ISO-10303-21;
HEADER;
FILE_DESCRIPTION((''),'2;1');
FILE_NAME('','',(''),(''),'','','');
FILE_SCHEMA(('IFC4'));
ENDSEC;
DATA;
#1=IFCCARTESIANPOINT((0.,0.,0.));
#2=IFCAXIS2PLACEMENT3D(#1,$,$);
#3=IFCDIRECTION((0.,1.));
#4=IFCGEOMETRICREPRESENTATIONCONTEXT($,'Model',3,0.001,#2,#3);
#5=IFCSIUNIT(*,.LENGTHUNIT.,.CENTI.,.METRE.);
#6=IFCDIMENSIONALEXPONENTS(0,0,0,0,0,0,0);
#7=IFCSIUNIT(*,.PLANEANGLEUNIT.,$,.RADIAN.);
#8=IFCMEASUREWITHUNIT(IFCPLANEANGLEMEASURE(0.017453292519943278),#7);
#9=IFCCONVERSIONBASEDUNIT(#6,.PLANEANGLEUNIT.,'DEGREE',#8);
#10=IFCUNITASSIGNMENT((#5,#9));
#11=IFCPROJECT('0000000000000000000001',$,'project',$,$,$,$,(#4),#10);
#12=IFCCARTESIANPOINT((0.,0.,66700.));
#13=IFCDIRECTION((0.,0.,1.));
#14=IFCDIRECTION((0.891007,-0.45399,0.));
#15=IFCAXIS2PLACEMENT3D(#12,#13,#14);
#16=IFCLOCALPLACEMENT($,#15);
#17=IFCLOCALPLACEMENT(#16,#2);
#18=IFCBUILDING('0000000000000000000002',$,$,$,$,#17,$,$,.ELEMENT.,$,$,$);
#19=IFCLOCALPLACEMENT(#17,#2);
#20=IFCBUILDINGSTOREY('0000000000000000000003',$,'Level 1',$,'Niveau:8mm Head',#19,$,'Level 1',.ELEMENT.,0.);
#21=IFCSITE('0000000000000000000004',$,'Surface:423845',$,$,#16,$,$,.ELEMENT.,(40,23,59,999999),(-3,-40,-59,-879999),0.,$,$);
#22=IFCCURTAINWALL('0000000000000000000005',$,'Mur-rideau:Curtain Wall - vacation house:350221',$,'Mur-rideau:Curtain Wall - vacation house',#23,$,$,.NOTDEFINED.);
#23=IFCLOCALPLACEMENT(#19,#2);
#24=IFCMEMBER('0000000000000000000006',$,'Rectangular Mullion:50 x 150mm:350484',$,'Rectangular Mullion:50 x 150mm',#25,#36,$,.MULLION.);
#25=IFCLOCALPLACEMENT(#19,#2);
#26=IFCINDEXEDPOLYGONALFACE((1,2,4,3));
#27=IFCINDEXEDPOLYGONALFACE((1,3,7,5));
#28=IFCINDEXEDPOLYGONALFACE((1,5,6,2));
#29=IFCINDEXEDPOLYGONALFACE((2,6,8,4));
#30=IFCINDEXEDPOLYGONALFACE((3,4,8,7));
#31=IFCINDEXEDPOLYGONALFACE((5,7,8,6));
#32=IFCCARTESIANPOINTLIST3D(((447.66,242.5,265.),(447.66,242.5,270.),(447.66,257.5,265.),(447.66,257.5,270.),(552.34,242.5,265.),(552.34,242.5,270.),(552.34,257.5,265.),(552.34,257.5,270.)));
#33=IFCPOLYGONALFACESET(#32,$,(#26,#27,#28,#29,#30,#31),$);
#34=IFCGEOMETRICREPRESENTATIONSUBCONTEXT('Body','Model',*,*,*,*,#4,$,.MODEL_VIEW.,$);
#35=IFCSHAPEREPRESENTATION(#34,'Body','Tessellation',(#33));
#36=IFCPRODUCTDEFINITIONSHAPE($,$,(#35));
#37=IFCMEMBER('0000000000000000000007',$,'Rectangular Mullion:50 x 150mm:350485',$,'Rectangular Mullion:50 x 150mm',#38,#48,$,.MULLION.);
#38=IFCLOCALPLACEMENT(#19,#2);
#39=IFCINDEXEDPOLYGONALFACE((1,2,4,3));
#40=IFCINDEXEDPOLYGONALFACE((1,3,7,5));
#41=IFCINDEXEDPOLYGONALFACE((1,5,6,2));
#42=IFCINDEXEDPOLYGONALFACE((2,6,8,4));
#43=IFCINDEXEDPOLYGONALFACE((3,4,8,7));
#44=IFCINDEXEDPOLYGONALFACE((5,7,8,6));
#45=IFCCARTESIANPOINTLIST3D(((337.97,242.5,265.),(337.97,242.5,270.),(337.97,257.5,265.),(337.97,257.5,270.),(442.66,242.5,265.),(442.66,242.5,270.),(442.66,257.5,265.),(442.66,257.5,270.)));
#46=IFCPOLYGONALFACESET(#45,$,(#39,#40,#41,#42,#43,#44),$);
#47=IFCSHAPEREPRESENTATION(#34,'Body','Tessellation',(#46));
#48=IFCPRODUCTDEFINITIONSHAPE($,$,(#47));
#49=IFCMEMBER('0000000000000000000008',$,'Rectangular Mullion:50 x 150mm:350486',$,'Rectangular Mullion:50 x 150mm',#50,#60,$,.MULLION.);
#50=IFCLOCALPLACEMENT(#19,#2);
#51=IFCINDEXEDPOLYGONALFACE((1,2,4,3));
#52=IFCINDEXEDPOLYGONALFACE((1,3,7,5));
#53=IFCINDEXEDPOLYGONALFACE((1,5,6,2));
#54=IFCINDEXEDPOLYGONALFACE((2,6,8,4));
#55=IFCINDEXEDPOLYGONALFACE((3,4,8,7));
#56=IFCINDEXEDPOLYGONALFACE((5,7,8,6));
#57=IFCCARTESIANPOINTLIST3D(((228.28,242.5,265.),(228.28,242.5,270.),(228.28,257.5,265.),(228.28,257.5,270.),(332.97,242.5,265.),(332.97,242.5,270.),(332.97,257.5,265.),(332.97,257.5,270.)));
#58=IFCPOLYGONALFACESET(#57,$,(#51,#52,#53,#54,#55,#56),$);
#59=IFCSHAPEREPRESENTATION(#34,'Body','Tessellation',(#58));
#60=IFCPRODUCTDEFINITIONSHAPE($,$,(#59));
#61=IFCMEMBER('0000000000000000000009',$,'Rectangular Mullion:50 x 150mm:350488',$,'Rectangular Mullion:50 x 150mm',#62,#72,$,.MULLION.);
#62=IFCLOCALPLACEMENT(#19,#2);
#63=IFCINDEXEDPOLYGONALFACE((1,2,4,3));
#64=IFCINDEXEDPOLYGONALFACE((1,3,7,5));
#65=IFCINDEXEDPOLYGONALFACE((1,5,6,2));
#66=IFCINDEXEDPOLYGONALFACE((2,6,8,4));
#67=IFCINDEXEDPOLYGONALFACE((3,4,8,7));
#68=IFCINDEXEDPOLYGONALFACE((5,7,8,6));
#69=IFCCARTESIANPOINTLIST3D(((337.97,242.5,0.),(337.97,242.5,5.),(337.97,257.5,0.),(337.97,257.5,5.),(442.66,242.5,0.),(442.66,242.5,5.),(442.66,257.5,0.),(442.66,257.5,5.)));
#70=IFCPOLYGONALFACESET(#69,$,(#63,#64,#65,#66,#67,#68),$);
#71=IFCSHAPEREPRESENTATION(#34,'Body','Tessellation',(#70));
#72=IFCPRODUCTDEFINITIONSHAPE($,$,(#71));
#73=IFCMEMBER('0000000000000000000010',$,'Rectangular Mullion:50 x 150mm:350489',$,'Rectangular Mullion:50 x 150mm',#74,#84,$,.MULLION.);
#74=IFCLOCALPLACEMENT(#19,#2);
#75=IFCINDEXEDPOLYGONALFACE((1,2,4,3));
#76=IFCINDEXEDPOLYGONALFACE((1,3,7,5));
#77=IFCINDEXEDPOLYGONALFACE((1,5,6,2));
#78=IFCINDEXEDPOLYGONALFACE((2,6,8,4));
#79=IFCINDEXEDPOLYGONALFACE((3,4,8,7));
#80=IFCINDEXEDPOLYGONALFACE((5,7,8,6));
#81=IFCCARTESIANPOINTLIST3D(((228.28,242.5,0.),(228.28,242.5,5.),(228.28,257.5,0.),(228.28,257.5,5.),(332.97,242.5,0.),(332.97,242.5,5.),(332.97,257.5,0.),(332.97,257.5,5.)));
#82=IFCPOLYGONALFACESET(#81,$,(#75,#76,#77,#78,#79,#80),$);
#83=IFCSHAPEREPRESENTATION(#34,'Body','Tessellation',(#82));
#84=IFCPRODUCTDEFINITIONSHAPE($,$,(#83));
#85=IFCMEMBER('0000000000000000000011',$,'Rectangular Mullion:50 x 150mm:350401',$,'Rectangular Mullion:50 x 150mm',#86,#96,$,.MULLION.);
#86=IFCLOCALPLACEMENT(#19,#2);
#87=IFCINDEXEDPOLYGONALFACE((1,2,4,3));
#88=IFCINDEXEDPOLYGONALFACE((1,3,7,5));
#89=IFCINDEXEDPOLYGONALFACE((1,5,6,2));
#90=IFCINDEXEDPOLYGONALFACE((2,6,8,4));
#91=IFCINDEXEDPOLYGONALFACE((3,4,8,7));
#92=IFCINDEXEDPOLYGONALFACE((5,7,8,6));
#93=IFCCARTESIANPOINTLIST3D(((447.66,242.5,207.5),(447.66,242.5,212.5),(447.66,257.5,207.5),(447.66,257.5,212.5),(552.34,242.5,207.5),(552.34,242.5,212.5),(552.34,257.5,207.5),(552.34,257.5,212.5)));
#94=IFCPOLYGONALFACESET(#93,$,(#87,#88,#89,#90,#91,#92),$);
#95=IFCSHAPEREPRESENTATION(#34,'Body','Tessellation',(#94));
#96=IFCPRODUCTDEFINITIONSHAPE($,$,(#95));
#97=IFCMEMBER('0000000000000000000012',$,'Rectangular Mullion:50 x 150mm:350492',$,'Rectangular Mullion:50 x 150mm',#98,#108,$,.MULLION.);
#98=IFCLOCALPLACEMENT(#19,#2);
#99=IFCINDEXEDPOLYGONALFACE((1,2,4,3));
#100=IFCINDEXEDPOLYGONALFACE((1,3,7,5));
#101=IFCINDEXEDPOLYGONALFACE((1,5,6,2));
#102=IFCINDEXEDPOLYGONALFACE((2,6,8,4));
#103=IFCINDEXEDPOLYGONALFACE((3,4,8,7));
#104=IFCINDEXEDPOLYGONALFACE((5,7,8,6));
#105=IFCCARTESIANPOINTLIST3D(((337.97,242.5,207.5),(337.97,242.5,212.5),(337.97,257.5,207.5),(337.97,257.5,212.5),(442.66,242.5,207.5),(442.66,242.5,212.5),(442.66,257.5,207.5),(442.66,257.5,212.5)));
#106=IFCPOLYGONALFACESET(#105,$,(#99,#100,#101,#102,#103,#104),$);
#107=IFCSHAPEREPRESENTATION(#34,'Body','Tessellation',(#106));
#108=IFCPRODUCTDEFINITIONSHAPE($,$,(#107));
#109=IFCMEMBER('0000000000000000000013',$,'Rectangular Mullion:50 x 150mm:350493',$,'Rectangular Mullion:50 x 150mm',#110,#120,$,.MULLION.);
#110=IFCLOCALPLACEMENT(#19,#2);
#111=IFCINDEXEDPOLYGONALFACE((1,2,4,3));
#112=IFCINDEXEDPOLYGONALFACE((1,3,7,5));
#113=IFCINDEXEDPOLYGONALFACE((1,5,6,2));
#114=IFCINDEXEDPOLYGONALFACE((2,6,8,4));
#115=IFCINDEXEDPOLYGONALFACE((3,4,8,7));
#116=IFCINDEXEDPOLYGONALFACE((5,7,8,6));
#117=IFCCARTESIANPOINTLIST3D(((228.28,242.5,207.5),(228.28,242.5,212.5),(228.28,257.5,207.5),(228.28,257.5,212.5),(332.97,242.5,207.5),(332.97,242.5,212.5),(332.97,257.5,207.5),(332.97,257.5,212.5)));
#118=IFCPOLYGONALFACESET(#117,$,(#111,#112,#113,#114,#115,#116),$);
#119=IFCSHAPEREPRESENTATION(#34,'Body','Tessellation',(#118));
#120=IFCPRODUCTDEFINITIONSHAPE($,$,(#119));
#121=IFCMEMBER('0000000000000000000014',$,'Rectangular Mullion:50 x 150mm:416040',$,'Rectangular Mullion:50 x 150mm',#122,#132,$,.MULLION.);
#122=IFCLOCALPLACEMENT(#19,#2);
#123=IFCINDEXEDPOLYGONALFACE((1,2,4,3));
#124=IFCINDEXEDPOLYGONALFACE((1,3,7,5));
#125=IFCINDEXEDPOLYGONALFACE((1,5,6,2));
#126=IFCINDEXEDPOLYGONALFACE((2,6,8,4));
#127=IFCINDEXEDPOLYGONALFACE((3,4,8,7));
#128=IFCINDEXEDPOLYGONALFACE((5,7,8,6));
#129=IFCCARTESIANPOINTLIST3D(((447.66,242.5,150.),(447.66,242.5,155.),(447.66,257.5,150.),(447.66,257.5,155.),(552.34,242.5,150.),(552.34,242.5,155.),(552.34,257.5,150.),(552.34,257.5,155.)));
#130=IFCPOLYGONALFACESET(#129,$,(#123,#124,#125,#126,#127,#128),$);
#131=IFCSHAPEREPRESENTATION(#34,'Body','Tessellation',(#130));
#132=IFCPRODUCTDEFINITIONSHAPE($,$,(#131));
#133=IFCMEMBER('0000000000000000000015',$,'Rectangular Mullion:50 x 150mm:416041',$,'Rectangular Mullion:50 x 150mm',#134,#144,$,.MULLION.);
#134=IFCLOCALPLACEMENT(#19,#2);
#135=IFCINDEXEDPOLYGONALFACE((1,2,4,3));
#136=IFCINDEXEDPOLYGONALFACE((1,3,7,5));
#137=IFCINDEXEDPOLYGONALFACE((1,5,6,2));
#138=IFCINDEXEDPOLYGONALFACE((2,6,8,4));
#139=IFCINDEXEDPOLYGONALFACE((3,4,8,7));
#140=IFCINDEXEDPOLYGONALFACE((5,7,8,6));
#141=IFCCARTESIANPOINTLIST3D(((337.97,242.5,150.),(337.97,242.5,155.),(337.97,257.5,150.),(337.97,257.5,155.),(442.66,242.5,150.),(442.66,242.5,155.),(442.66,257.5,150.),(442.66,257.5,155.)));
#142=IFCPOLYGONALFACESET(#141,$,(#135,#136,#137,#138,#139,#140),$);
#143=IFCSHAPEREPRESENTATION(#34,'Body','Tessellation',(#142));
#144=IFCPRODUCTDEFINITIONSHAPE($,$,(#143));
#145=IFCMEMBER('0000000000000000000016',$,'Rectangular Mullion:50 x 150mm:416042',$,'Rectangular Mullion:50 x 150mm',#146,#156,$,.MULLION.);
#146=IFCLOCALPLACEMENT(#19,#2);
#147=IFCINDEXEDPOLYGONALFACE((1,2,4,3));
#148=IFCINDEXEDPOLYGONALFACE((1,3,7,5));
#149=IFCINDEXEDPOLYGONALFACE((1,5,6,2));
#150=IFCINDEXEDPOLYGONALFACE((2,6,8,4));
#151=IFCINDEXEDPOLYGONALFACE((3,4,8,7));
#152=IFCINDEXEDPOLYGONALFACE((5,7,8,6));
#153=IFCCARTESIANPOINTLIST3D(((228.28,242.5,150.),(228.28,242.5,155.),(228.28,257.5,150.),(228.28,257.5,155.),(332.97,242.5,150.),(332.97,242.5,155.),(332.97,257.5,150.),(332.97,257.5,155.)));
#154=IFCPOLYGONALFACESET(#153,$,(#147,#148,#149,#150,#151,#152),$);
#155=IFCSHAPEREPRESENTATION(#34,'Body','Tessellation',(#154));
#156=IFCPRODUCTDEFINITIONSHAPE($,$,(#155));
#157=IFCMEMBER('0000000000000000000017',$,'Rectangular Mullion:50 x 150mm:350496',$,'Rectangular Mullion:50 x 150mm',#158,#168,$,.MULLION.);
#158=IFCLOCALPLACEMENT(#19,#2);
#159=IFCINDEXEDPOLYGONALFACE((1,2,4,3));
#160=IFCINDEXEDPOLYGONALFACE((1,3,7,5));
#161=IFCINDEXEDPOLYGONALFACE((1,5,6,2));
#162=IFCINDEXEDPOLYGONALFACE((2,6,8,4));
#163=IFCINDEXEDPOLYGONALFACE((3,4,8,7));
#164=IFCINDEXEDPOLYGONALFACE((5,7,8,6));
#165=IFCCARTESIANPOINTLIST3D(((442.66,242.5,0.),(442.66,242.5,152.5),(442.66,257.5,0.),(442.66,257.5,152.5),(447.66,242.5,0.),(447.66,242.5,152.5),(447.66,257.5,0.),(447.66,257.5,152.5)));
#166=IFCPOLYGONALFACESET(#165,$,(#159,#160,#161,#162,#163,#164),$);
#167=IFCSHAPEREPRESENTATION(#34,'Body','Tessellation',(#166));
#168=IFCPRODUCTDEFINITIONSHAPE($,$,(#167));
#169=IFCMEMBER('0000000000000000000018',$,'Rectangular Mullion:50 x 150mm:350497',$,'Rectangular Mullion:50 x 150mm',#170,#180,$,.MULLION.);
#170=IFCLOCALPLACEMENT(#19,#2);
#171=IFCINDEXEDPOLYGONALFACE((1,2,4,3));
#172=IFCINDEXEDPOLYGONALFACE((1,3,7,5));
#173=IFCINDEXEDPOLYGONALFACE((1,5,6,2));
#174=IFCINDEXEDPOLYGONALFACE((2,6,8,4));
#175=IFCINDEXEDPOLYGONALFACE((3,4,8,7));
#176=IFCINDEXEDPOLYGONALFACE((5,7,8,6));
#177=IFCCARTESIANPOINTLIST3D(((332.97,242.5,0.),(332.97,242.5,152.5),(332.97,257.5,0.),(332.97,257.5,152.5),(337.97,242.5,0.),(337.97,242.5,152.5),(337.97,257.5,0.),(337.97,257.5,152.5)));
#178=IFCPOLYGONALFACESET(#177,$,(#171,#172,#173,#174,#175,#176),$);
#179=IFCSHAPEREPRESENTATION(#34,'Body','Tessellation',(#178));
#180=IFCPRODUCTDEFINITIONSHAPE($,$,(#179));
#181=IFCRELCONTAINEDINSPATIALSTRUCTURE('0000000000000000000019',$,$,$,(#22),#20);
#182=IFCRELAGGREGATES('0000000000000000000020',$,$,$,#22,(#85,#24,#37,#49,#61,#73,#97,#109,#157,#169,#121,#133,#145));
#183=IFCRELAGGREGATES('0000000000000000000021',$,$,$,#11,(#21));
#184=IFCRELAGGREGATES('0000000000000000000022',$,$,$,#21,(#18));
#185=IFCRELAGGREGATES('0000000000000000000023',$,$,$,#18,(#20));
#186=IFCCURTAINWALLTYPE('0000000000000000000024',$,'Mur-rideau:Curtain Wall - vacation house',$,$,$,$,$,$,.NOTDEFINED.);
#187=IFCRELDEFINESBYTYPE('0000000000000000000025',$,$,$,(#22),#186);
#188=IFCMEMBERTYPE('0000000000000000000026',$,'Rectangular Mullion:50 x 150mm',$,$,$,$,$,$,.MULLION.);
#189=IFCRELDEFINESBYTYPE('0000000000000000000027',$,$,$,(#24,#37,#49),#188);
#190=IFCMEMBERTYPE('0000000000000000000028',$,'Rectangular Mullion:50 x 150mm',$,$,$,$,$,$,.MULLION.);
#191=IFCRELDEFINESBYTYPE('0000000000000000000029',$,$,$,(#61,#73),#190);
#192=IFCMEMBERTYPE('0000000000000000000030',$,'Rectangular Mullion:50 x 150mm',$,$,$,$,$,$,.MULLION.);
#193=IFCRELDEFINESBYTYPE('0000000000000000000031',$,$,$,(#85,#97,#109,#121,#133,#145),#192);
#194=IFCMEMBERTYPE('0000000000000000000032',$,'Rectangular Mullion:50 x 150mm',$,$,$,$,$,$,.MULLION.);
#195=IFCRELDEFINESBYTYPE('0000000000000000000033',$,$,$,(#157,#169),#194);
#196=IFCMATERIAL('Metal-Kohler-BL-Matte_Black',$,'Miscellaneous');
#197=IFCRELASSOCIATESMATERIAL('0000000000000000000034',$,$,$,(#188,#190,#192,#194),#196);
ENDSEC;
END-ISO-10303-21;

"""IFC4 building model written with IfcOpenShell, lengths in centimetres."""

from ifc_helpers import new_model, entity, si_unit, converted_unit, direction, frame, origin, origin_2d_with_axis, place, context, subcontext, project, spatial, rectangle, extrude, source, transform, mapped, material, material_profile, profile_set, type_object, type_shapes, element, aggregate, save


model = new_model("IFC4")

# Units and contexts
model_context = context("Model", 3, precision=0.001, world=origin(), true_north=direction((0.0, 1.0)))
body_context = subcontext(model_context, "Body", "Model", "MODEL_VIEW")
ifc_project = project(units=[si_unit("LENGTHUNIT", "METRE", prefix="CENTI"), converted_unit("PLANEANGLEUNIT", "DEGREE", entity("IfcPlaneAngleMeasure", 0.017453292519943278), si_unit("PLANEANGLEUNIT", "RADIAN"), dimensions=[0, 0, 0, 0, 0, 0, 0])], contexts=[model_context])

# Site, building, storey
site_placement = place(None, frame((0.0, 0.0, 66700.0), z_axis=(0.0, 0.0, 1.0), x_axis=(0.891007, -0.45399, 0.0)))
site = spatial("IfcSite", under=ifc_project, at=site_placement, Name="Surface:423845", CompositionType="ELEMENT", RefLatitude=(40, 23, 59, 999999), RefLongitude=(-3, -40, -59, -879999), RefElevation=0.0)
building_placement = place(site_placement, origin())
building = spatial("IfcBuilding", under=site, at=building_placement, CompositionType="ELEMENT")
storey_placement = place(building_placement, origin())
storey = spatial("IfcBuildingStorey", under=building, at=storey_placement, Name="Level 1", ObjectType="Niveau:8mm Head", LongName="Level 1", CompositionType="ELEMENT", Elevation=0.0)

# Curtain wall, members
curtain_wall_type = type_object("IfcCurtainWallType", Name="Mur-rideau:Curtain Wall - vacation house", PredefinedType="NOTDEFINED")
curtain_wall_placement = place(storey_placement, origin())
curtain_wall = element("IfcCurtainWall", 1, at=curtain_wall_placement, inside=storey, type_object=curtain_wall_type, Name="Mur-rideau:Curtain Wall - vacation house:350221", ObjectType="Mur-rideau:Curtain Wall - vacation house", PredefinedType="NOTDEFINED")
ifc_material_1 = material(Name="Metal-Kohler-BL-Matte_Black", Category="Miscellaneous")
ifc_material_profile = material_profile(ifc_material_1, rectangle(XDim=5.0, YDim=15.0, at=origin_2d_with_axis()), Name="50 x 150mm")
ifc_profile_set = profile_set([ifc_material_profile], Name="50 x 150mm")
member_type_1 = type_object("IfcMemberType", Name="Rectangular Mullion:50 x 150mm", PredefinedType="MULLION", material=ifc_profile_set)
shared_shape_1 = source(origin(), body_context, "Body", "SweptSolid", [
    extrude(rectangle(XDim=5.0, YDim=15.0, at=origin_2d_with_axis()), frame((-2.5, 0.0, -104.69), z_axis=(0.0, 0.0, 1.0), x_axis=(-1.0, 0.0, 0.0)), (0.0, 0.0, 1.0), 104.69),
])
type_shapes(member_type_1, [shared_shape_1])
member_1_placement = place(curtain_wall_placement, frame((447.66, 250.0, 270.0), z_axis=(-1.0, 0.0, 0.0), x_axis=(0.0, 0.0, 1.0)))
member_1 = element("IfcMember", 2, at=member_1_placement, type_object=member_type_1, Name="Rectangular Mullion:50 x 150mm:350484", ObjectType="Rectangular Mullion:50 x 150mm", PredefinedType="MULLION", context=body_context, shape_type="MappedRepresentation", body=[
    mapped(shared_shape_1, transform((0.0, 0.0, 0.0), scale=1.0)),
])
member_2_placement = place(curtain_wall_placement, frame((337.97, 250.0, 270.0), z_axis=(-1.0, 0.0, 0.0), x_axis=(0.0, 0.0, 1.0)))
member_2 = element("IfcMember", 3, at=member_2_placement, type_object=member_type_1, Name="Rectangular Mullion:50 x 150mm:350485", ObjectType="Rectangular Mullion:50 x 150mm", PredefinedType="MULLION", context=body_context, shape_type="MappedRepresentation", body=[
    mapped(shared_shape_1, transform((0.0, 0.0, 0.0), scale=1.0)),
])
member_3_placement = place(curtain_wall_placement, frame((228.28, 250.0, 270.0), z_axis=(-1.0, 0.0, 0.0), x_axis=(0.0, 0.0, 1.0)))
member_3 = element("IfcMember", 4, at=member_3_placement, type_object=member_type_1, Name="Rectangular Mullion:50 x 150mm:350486", ObjectType="Rectangular Mullion:50 x 150mm", PredefinedType="MULLION", context=body_context, shape_type="MappedRepresentation", body=[
    mapped(shared_shape_1, transform((0.0, 0.0, 0.0), scale=1.0)),
])
member_type_2 = type_object("IfcMemberType", Name="Rectangular Mullion:50 x 150mm", PredefinedType="MULLION", material=ifc_profile_set)
shared_shape_2 = source(origin(), body_context, "Body", "SweptSolid", [
    extrude(rectangle(XDim=5.0, YDim=15.0, at=origin_2d_with_axis()), frame((-2.5, 0.0, -104.69), z_axis=(0.0, 0.0, 1.0), x_axis=(-1.0, 0.0, 0.0)), (0.0, 0.0, 1.0), 104.69),
])
type_shapes(member_type_2, [shared_shape_2])
member_4_placement = place(curtain_wall_placement, frame((442.66, 250.0, 0.0), z_axis=(1.0, 0.0, 0.0), x_axis=(0.0, 0.0, -1.0)))
member_4 = element("IfcMember", 5, at=member_4_placement, type_object=member_type_2, Name="Rectangular Mullion:50 x 150mm:350488", ObjectType="Rectangular Mullion:50 x 150mm", PredefinedType="MULLION", context=body_context, shape_type="MappedRepresentation", body=[
    mapped(shared_shape_2, transform((0.0, 0.0, 0.0), scale=1.0)),
])
member_5_placement = place(curtain_wall_placement, frame((332.97, 250.0, 0.0), z_axis=(1.0, 0.0, 0.0), x_axis=(0.0, 0.0, -1.0)))
member_5 = element("IfcMember", 6, at=member_5_placement, type_object=member_type_2, Name="Rectangular Mullion:50 x 150mm:350489", ObjectType="Rectangular Mullion:50 x 150mm", PredefinedType="MULLION", context=body_context, shape_type="MappedRepresentation", body=[
    mapped(shared_shape_2, transform((0.0, 0.0, 0.0), scale=1.0)),
])
member_type_3 = type_object("IfcMemberType", Name="Rectangular Mullion:50 x 150mm", PredefinedType="MULLION", material=ifc_profile_set)
shared_shape_3 = source(origin(), body_context, "Body", "SweptSolid", [
    extrude(rectangle(XDim=5.0, YDim=15.0, at=origin_2d_with_axis()), frame((0.0, 0.0, -104.69), z_axis=(0.0, 0.0, 1.0), x_axis=(-1.0, 0.0, 0.0)), (0.0, 0.0, 1.0), 104.69),
])
type_shapes(member_type_3, [shared_shape_3])
member_6_placement = place(curtain_wall_placement, frame((447.66, 250.0, 210.0), z_axis=(-1.0, 0.0, 0.0), x_axis=(0.0, 0.0, 1.0)))
member_6 = element("IfcMember", 7, at=member_6_placement, type_object=member_type_3, Name="Rectangular Mullion:50 x 150mm:350401", ObjectType="Rectangular Mullion:50 x 150mm", PredefinedType="MULLION", context=body_context, shape_type="MappedRepresentation", body=[
    mapped(shared_shape_3, transform((0.0, 0.0, 0.0), scale=1.0)),
])
member_7_placement = place(curtain_wall_placement, frame((337.97, 250.0, 210.0), z_axis=(-1.0, 0.0, 0.0), x_axis=(0.0, 0.0, 1.0)))
member_7 = element("IfcMember", 8, at=member_7_placement, type_object=member_type_3, Name="Rectangular Mullion:50 x 150mm:350492", ObjectType="Rectangular Mullion:50 x 150mm", PredefinedType="MULLION", context=body_context, shape_type="MappedRepresentation", body=[
    mapped(shared_shape_3, transform((0.0, 0.0, 0.0), scale=1.0)),
])
member_8_placement = place(curtain_wall_placement, frame((228.28, 250.0, 210.0), z_axis=(-1.0, 0.0, 0.0), x_axis=(0.0, 0.0, 1.0)))
member_8 = element("IfcMember", 9, at=member_8_placement, type_object=member_type_3, Name="Rectangular Mullion:50 x 150mm:350493", ObjectType="Rectangular Mullion:50 x 150mm", PredefinedType="MULLION", context=body_context, shape_type="MappedRepresentation", body=[
    mapped(shared_shape_3, transform((0.0, 0.0, 0.0), scale=1.0)),
])
member_9_placement = place(curtain_wall_placement, frame((447.66, 250.0, 152.5), z_axis=(-1.0, 0.0, 0.0), x_axis=(0.0, 0.0, 1.0)))
member_9 = element("IfcMember", 10, at=member_9_placement, type_object=member_type_3, Name="Rectangular Mullion:50 x 150mm:416040", ObjectType="Rectangular Mullion:50 x 150mm", PredefinedType="MULLION", context=body_context, shape_type="MappedRepresentation", body=[
    mapped(shared_shape_3, transform((0.0, 0.0, 0.0), scale=1.0)),
])
member_10_placement = place(curtain_wall_placement, frame((337.97, 250.0, 152.5), z_axis=(-1.0, 0.0, 0.0), x_axis=(0.0, 0.0, 1.0)))
member_10 = element("IfcMember", 11, at=member_10_placement, type_object=member_type_3, Name="Rectangular Mullion:50 x 150mm:416041", ObjectType="Rectangular Mullion:50 x 150mm", PredefinedType="MULLION", context=body_context, shape_type="MappedRepresentation", body=[
    mapped(shared_shape_3, transform((0.0, 0.0, 0.0), scale=1.0)),
])
member_11_placement = place(curtain_wall_placement, frame((228.28, 250.0, 152.5), z_axis=(-1.0, 0.0, 0.0), x_axis=(0.0, 0.0, 1.0)))
member_11 = element("IfcMember", 12, at=member_11_placement, type_object=member_type_3, Name="Rectangular Mullion:50 x 150mm:416042", ObjectType="Rectangular Mullion:50 x 150mm", PredefinedType="MULLION", context=body_context, shape_type="MappedRepresentation", body=[
    mapped(shared_shape_3, transform((0.0, 0.0, 0.0), scale=1.0)),
])
member_type_4 = type_object("IfcMemberType", Name="Rectangular Mullion:50 x 150mm", PredefinedType="MULLION", material=ifc_profile_set)
shared_shape_4 = source(origin(), body_context, "Body", "SweptSolid", [
    extrude(rectangle(XDim=5.0, YDim=15.0, at=origin_2d_with_axis()), frame((0.0, 0.0, -152.5), z_axis=(0.0, 0.0, 1.0), x_axis=(-1.0, 0.0, 0.0)), (0.0, 0.0, 1.0), 152.5),
])
type_shapes(member_type_4, [shared_shape_4])
member_12_placement = place(curtain_wall_placement, frame((445.16, 250.0, 0.0), z_axis=(0.0, 0.0, -1.0), x_axis=(-1.0, 0.0, 0.0)))
member_12 = element("IfcMember", 13, at=member_12_placement, type_object=member_type_4, Name="Rectangular Mullion:50 x 150mm:350496", ObjectType="Rectangular Mullion:50 x 150mm", PredefinedType="MULLION", context=body_context, shape_type="MappedRepresentation", body=[
    mapped(shared_shape_4, transform((0.0, 0.0, 0.0), scale=1.0)),
])
member_13_placement = place(curtain_wall_placement, frame((335.47, 250.0, 0.0), z_axis=(0.0, 0.0, -1.0), x_axis=(-1.0, 0.0, 0.0)))
member_13 = element("IfcMember", 14, at=member_13_placement, type_object=member_type_4, Name="Rectangular Mullion:50 x 150mm:350497", ObjectType="Rectangular Mullion:50 x 150mm", PredefinedType="MULLION", context=body_context, shape_type="MappedRepresentation", body=[
    mapped(shared_shape_4, transform((0.0, 0.0, 0.0), scale=1.0)),
])

aggregate(curtain_wall, [member_6, member_1, member_2, member_3, member_4, member_5, member_7, member_8, member_12, member_13, member_9, member_10, member_11])

save(model, "model.ifc")
